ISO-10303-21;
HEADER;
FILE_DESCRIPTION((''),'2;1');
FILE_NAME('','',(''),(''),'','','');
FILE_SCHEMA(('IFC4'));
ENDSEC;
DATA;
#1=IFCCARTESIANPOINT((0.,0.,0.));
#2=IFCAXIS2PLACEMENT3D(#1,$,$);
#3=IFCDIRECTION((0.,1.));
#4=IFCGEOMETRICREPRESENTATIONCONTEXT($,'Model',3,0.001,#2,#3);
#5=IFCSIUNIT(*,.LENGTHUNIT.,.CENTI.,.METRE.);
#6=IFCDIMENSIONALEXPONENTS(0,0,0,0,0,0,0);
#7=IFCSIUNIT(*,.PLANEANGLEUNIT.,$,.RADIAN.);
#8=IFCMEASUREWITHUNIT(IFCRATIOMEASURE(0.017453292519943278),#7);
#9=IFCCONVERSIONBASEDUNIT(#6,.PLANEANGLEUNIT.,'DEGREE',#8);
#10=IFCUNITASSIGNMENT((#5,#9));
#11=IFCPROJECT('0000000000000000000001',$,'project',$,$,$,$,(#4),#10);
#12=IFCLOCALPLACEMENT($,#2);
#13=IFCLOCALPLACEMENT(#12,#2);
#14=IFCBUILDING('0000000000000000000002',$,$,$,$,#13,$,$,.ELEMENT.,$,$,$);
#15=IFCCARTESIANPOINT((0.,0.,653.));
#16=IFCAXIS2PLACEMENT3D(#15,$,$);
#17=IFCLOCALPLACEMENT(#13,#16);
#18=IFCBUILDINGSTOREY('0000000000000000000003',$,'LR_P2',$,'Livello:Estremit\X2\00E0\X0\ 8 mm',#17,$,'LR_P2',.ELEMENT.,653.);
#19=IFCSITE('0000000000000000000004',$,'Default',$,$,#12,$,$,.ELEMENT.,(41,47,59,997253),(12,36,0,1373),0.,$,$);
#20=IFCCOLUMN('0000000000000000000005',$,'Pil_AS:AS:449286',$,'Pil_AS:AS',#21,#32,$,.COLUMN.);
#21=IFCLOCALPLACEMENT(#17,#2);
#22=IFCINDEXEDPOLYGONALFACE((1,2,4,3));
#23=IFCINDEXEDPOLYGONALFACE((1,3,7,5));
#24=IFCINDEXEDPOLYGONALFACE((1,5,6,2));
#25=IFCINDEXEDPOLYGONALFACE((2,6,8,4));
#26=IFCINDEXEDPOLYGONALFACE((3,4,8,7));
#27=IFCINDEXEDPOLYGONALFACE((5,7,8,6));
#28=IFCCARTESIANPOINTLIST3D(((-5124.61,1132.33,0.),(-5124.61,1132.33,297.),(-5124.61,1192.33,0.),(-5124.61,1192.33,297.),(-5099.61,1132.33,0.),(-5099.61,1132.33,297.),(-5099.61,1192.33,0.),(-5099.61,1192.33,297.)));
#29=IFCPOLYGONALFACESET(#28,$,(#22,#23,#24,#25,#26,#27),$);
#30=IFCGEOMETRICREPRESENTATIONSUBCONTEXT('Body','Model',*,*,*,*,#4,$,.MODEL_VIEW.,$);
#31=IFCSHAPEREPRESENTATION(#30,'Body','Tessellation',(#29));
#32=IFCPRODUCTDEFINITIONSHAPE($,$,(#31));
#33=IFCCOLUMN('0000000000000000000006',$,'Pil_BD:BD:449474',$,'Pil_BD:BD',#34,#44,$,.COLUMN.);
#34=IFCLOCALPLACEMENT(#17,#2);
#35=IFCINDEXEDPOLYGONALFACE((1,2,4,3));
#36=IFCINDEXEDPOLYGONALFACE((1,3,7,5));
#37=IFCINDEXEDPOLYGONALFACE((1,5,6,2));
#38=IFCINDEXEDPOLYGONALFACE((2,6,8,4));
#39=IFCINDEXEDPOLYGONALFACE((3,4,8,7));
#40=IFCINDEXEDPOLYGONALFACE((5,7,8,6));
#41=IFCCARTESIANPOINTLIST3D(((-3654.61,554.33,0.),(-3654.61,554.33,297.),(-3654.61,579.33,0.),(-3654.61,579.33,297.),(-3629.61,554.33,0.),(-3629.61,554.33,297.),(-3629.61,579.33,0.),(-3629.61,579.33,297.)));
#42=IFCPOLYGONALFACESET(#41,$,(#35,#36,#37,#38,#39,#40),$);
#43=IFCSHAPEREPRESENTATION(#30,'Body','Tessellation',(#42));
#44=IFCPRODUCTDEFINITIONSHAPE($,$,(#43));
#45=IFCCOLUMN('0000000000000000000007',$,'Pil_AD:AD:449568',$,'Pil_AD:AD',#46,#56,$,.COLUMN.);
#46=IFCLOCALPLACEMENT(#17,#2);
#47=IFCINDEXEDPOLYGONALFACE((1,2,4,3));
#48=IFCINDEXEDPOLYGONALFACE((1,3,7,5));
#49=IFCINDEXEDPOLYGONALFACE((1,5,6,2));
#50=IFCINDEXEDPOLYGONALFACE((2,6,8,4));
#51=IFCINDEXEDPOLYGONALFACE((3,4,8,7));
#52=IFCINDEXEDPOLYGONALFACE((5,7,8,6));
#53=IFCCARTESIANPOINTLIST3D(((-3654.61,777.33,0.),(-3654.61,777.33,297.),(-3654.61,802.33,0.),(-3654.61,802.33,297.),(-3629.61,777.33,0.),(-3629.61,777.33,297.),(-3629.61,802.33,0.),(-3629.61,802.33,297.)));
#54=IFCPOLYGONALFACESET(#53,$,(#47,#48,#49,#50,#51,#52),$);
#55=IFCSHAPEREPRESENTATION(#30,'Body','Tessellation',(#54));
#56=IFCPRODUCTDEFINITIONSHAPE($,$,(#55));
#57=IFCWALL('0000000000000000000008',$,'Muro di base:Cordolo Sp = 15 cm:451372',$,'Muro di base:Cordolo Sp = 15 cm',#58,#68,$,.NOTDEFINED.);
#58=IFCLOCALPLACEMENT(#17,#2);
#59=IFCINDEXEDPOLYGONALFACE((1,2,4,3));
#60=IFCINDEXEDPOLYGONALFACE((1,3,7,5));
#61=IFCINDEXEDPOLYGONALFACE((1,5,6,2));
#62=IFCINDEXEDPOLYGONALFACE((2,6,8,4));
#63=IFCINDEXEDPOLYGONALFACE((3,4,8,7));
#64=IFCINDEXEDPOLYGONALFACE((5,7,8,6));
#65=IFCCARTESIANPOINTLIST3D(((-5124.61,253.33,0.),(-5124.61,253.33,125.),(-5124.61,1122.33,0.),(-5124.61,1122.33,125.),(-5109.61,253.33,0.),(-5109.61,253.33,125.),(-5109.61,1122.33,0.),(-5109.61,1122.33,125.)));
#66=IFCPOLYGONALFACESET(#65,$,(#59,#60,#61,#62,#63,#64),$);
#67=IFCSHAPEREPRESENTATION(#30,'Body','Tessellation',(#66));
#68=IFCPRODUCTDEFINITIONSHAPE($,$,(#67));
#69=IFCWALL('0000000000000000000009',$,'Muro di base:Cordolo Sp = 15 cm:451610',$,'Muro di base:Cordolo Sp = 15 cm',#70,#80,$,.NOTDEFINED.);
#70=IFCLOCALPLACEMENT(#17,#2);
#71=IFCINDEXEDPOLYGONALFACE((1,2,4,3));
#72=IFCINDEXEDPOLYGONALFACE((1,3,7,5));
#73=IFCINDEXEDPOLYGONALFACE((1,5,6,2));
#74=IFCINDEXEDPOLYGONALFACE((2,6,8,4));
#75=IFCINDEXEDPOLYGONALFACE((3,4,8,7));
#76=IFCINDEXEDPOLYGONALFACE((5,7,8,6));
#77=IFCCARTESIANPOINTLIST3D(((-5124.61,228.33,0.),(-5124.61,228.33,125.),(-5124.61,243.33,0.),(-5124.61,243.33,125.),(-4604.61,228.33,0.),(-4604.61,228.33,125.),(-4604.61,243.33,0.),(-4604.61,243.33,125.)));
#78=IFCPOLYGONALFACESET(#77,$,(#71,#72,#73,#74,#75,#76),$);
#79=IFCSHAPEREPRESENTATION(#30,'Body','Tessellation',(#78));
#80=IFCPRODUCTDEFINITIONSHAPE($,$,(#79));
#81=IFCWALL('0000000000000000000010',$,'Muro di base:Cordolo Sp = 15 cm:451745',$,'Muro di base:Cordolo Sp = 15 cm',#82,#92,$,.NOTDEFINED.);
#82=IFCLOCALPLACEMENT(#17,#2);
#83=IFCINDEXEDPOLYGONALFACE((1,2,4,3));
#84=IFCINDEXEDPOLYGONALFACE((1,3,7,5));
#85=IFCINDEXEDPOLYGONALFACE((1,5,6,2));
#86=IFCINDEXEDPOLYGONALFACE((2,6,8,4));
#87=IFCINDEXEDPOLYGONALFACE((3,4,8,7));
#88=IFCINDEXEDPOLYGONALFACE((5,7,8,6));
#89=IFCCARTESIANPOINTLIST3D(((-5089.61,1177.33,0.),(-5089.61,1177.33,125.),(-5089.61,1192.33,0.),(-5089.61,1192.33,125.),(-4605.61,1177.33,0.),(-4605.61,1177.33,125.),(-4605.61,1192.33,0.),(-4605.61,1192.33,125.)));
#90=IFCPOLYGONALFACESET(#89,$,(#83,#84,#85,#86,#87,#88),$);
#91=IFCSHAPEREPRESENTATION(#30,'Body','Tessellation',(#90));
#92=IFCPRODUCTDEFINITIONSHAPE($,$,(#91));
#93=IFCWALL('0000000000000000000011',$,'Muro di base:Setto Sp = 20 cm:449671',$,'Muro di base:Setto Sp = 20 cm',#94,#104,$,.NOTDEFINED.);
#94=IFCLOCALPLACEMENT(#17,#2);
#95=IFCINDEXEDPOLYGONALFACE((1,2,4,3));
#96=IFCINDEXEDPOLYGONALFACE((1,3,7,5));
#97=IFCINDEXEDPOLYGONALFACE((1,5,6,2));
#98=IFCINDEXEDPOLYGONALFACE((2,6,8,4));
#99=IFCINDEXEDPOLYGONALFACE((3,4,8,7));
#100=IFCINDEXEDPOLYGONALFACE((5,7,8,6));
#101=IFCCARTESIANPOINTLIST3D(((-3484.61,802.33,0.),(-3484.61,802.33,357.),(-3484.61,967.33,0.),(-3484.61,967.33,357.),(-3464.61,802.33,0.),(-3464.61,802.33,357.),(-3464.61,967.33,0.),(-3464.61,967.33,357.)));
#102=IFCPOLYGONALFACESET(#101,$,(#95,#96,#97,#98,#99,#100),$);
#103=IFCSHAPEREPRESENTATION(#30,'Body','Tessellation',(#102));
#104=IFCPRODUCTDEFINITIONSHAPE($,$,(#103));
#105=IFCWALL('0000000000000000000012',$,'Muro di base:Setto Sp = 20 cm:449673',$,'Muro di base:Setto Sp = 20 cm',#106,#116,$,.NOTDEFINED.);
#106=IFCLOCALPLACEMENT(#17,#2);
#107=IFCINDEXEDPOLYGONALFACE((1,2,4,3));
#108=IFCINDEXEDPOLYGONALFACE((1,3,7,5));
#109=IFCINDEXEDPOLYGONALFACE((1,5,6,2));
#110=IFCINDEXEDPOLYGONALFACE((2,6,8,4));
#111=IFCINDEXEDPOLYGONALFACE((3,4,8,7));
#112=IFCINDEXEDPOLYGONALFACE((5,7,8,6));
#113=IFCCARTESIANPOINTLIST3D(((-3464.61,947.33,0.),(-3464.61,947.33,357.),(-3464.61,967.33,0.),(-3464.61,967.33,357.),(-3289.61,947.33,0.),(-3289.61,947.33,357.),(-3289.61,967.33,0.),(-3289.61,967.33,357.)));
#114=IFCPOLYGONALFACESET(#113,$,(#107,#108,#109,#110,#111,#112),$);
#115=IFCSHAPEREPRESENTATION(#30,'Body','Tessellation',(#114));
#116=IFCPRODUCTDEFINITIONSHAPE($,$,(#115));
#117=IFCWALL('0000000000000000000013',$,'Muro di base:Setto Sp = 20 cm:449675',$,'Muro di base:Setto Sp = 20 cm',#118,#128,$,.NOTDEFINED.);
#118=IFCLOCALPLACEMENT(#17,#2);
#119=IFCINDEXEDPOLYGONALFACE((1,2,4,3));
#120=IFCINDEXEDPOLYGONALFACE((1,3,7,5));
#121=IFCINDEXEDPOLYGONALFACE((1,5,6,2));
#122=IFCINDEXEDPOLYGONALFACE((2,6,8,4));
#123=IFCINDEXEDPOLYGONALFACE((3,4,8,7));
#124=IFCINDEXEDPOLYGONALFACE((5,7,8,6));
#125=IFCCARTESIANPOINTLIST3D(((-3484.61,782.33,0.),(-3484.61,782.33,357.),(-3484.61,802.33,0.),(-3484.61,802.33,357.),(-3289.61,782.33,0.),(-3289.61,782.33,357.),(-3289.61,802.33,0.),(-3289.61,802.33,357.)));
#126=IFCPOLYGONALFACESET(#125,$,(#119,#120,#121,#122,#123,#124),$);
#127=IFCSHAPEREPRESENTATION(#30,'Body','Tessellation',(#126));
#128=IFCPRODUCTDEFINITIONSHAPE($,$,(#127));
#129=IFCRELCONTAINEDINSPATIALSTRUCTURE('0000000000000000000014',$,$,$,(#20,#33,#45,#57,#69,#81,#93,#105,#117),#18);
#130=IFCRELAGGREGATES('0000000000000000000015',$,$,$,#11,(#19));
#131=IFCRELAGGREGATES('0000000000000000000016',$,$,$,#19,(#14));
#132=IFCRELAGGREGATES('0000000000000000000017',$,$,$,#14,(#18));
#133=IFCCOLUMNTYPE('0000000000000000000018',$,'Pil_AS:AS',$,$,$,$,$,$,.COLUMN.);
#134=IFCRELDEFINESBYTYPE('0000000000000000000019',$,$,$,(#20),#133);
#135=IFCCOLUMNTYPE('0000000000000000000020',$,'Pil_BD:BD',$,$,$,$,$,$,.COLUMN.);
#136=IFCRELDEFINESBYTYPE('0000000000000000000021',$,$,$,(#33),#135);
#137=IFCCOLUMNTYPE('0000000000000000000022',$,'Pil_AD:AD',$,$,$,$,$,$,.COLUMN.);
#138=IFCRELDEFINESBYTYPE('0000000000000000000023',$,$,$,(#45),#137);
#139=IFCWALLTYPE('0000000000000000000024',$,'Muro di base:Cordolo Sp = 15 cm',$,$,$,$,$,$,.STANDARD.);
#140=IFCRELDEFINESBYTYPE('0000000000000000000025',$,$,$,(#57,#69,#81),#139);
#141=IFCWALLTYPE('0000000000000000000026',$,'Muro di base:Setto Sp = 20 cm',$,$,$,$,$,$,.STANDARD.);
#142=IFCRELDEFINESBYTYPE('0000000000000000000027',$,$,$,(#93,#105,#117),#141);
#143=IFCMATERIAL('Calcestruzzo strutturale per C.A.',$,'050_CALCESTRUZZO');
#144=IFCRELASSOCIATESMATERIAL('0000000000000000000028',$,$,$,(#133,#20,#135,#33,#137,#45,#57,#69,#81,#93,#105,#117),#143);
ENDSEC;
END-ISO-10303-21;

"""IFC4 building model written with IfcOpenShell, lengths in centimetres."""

from ifc_helpers import new_model, entity, si_unit, converted_unit, direction, frame, origin, place, context, subcontext, project, spatial, indexed_curve, outline, extrude, source, transform, mapped, material, type_object, type_shapes, element, save


model = new_model("IFC4")

# Units and contexts
model_context = context("Model", 3, precision=0.001, world=origin(), true_north=direction((0.0, 1.0)))
body_context = subcontext(model_context, "Body", "Model", "MODEL_VIEW")
ifc_project = project(units=[si_unit("LENGTHUNIT", "METRE", prefix="CENTI"), converted_unit("PLANEANGLEUNIT", "DEGREE", entity("IfcRatioMeasure", 0.017453292519943278), si_unit("PLANEANGLEUNIT", "RADIAN"), dimensions=[0, 0, 0, 0, 0, 0, 0])], contexts=[model_context])

# Site, building, storey
site_placement = place(None, origin())
site = spatial("IfcSite", under=ifc_project, at=site_placement, Name="Default", CompositionType="ELEMENT", RefLatitude=(41, 47, 59, 997253), RefLongitude=(12, 36, 0, 1373), RefElevation=0.0)
building_placement = place(site_placement, origin())
building = spatial("IfcBuilding", under=site, at=building_placement, CompositionType="ELEMENT")
storey_placement = place(building_placement, frame((0.0, 0.0, 653.0)))
storey = spatial("IfcBuildingStorey", under=building, at=storey_placement, Name="LR_P2", ObjectType="Livello:Estremità 8 mm", LongName="LR_P2", CompositionType="ELEMENT", Elevation=653.0)

# Columns
ifc_material = material(Name="Calcestruzzo strutturale per C.A.", Category="050_CALCESTRUZZO")
column_type_1 = type_object("IfcColumnType", Name="Pil_AS:AS", PredefinedType="COLUMN", material=ifc_material)
shared_shape_1 = source(origin(), body_context, "Body", "SweptSolid", [
    extrude(outline(indexed_curve([(-30.0, -12.5), (30.0, -12.5), (30.0, 12.5), (-30.0, 12.5), (-30.0, -12.5)], self_intersect=False)), frame((-5112.11, 1162.33, 653.0), z_axis=(0.0, 0.0, 1.0), x_axis=(0.0, -1.0, 0.0)), (0.0, 0.0, 1.0), 297.0),
])
type_shapes(column_type_1, [shared_shape_1])
column_1_placement = place(storey_placement, frame((0.0, 0.0, -653.0)))
element("IfcColumn", 1, at=column_1_placement, inside=storey, type_object=column_type_1, material=ifc_material, Name="Pil_AS:AS:449286", ObjectType="Pil_AS:AS", PredefinedType="COLUMN", context=body_context, shape_type="MappedRepresentation", body=[
    mapped(shared_shape_1, transform((0.0, 0.0, 0.0), scale=1.0)),
])
column_type_2 = type_object("IfcColumnType", Name="Pil_BD:BD", PredefinedType="COLUMN", material=ifc_material)
shared_shape_2 = source(origin(), body_context, "Body", "SweptSolid", [
    extrude(outline(indexed_curve([(-12.5, -12.5), (12.5, -12.5), (12.5, 12.5), (-12.5, 12.5), (-12.5, -12.5)], self_intersect=False)), frame((-3642.11, 566.83, 653.0), z_axis=(0.0, 0.0, 1.0), x_axis=(0.0, -1.0, 0.0)), (0.0, 0.0, 1.0), 297.0),
])
type_shapes(column_type_2, [shared_shape_2])
column_2_placement = place(storey_placement, frame((0.0, 0.0, -653.0)))
element("IfcColumn", 2, at=column_2_placement, inside=storey, type_object=column_type_2, material=ifc_material, Name="Pil_BD:BD:449474", ObjectType="Pil_BD:BD", PredefinedType="COLUMN", context=body_context, shape_type="MappedRepresentation", body=[
    mapped(shared_shape_2, transform((0.0, 0.0, 0.0), scale=1.0)),
])
column_type_3 = type_object("IfcColumnType", Name="Pil_AD:AD", PredefinedType="COLUMN", material=ifc_material)
shared_shape_3 = source(origin(), body_context, "Body", "SweptSolid", [
    extrude(outline(indexed_curve([(-12.5, -12.5), (12.5, -12.5), (12.5, 12.5), (-12.5, 12.5), (-12.5, -12.5)], self_intersect=False)), frame((-3642.11, 789.83, 653.0), z_axis=(0.0, 0.0, 1.0), x_axis=(0.0, -1.0, 0.0)), (0.0, 0.0, 1.0), 297.0),
])
type_shapes(column_type_3, [shared_shape_3])
column_3_placement = place(storey_placement, frame((0.0, 0.0, -653.0)))
element("IfcColumn", 3, at=column_3_placement, inside=storey, type_object=column_type_3, material=ifc_material, Name="Pil_AD:AD:449568", ObjectType="Pil_AD:AD", PredefinedType="COLUMN", context=body_context, shape_type="MappedRepresentation", body=[
    mapped(shared_shape_3, transform((0.0, 0.0, 0.0), scale=1.0)),
])

# Walls
wall_type_1 = type_object("IfcWallType", Name="Muro di base:Cordolo Sp = 15 cm", PredefinedType="STANDARD")
wall_1_placement = place(storey_placement, frame((-5117.11, 1122.33, 0.0), z_axis=(0.0, 0.0, 1.0), x_axis=(0.0, -1.0, 0.0)))
element("IfcWall", 4, at=wall_1_placement, inside=storey, type_object=wall_type_1, material=ifc_material, Name="Muro di base:Cordolo Sp = 15 cm:451372", ObjectType="Muro di base:Cordolo Sp = 15 cm", PredefinedType="NOTDEFINED", context=body_context, shape_type="SweptSolid", body=[
    extrude(outline(indexed_curve([(869.0, 7.5), (0.0, 7.5), (0.0, -7.5), (869.0, -7.5), (869.0, 7.5)], self_intersect=False)), origin(), (0.0, 0.0, 1.0), 125.0),
])
wall_2_placement = place(storey_placement, frame((-5124.61, 235.83, 0.0)))
element("IfcWall", 5, at=wall_2_placement, inside=storey, type_object=wall_type_1, material=ifc_material, Name="Muro di base:Cordolo Sp = 15 cm:451610", ObjectType="Muro di base:Cordolo Sp = 15 cm", PredefinedType="NOTDEFINED", context=body_context, shape_type="SweptSolid", body=[
    extrude(outline(indexed_curve([(520.0, 7.5), (0.0, 7.5), (0.0, -7.5), (520.0, -7.5), (520.0, 7.5)], self_intersect=False)), origin(), (0.0, 0.0, 1.0), 125.0),
])
wall_3_placement = place(storey_placement, frame((-5089.61, 1184.83, 0.0)))
element("IfcWall", 6, at=wall_3_placement, inside=storey, type_object=wall_type_1, material=ifc_material, Name="Muro di base:Cordolo Sp = 15 cm:451745", ObjectType="Muro di base:Cordolo Sp = 15 cm", PredefinedType="NOTDEFINED", context=body_context, shape_type="SweptSolid", body=[
    extrude(outline(indexed_curve([(484.0, 7.5), (0.0, 7.5), (0.0, -7.5), (484.0, -7.5), (484.0, 7.5)], self_intersect=False)), origin(), (0.0, 0.0, 1.0), 125.0),
])
wall_type_2 = type_object("IfcWallType", Name="Muro di base:Setto Sp = 20 cm", PredefinedType="STANDARD")
wall_4_placement = place(storey_placement, frame((-3474.61, 802.33, 0.0), z_axis=(0.0, 0.0, 1.0), x_axis=(0.0, 1.0, 0.0)))
element("IfcWall", 7, at=wall_4_placement, inside=storey, type_object=wall_type_2, material=ifc_material, Name="Muro di base:Setto Sp = 20 cm:449671", ObjectType="Muro di base:Setto Sp = 20 cm", PredefinedType="NOTDEFINED", context=body_context, shape_type="SweptSolid", body=[
    extrude(outline(indexed_curve([(165.0, 10.0), (0.0, 10.0), (0.0, -10.0), (165.0, -10.0), (165.0, 10.0)], self_intersect=False)), origin(), (0.0, 0.0, 1.0), 357.0),
])
wall_5_placement = place(storey_placement, frame((-3464.61, 957.33, 0.0)))
element("IfcWall", 8, at=wall_5_placement, inside=storey, type_object=wall_type_2, material=ifc_material, Name="Muro di base:Setto Sp = 20 cm:449673", ObjectType="Muro di base:Setto Sp = 20 cm", PredefinedType="NOTDEFINED", context=body_context, shape_type="SweptSolid", body=[
    extrude(outline(indexed_curve([(175.0, 10.0), (0.0, 10.0), (0.0, -10.0), (175.0, -10.0), (175.0, 10.0)], self_intersect=False)), origin(), (0.0, 0.0, 1.0), 357.0),
])
wall_6_placement = place(storey_placement, frame((-3484.61, 792.33, 0.0)))
element("IfcWall", 9, at=wall_6_placement, inside=storey, type_object=wall_type_2, material=ifc_material, Name="Muro di base:Setto Sp = 20 cm:449675", ObjectType="Muro di base:Setto Sp = 20 cm", PredefinedType="NOTDEFINED", context=body_context, shape_type="SweptSolid", body=[
    extrude(outline(indexed_curve([(195.0, 10.0), (0.0, 10.0), (0.0, -10.0), (195.0, -10.0), (195.0, 10.0)], self_intersect=False)), origin(), (0.0, 0.0, 1.0), 357.0),
])

save(model, "model.ifc")
